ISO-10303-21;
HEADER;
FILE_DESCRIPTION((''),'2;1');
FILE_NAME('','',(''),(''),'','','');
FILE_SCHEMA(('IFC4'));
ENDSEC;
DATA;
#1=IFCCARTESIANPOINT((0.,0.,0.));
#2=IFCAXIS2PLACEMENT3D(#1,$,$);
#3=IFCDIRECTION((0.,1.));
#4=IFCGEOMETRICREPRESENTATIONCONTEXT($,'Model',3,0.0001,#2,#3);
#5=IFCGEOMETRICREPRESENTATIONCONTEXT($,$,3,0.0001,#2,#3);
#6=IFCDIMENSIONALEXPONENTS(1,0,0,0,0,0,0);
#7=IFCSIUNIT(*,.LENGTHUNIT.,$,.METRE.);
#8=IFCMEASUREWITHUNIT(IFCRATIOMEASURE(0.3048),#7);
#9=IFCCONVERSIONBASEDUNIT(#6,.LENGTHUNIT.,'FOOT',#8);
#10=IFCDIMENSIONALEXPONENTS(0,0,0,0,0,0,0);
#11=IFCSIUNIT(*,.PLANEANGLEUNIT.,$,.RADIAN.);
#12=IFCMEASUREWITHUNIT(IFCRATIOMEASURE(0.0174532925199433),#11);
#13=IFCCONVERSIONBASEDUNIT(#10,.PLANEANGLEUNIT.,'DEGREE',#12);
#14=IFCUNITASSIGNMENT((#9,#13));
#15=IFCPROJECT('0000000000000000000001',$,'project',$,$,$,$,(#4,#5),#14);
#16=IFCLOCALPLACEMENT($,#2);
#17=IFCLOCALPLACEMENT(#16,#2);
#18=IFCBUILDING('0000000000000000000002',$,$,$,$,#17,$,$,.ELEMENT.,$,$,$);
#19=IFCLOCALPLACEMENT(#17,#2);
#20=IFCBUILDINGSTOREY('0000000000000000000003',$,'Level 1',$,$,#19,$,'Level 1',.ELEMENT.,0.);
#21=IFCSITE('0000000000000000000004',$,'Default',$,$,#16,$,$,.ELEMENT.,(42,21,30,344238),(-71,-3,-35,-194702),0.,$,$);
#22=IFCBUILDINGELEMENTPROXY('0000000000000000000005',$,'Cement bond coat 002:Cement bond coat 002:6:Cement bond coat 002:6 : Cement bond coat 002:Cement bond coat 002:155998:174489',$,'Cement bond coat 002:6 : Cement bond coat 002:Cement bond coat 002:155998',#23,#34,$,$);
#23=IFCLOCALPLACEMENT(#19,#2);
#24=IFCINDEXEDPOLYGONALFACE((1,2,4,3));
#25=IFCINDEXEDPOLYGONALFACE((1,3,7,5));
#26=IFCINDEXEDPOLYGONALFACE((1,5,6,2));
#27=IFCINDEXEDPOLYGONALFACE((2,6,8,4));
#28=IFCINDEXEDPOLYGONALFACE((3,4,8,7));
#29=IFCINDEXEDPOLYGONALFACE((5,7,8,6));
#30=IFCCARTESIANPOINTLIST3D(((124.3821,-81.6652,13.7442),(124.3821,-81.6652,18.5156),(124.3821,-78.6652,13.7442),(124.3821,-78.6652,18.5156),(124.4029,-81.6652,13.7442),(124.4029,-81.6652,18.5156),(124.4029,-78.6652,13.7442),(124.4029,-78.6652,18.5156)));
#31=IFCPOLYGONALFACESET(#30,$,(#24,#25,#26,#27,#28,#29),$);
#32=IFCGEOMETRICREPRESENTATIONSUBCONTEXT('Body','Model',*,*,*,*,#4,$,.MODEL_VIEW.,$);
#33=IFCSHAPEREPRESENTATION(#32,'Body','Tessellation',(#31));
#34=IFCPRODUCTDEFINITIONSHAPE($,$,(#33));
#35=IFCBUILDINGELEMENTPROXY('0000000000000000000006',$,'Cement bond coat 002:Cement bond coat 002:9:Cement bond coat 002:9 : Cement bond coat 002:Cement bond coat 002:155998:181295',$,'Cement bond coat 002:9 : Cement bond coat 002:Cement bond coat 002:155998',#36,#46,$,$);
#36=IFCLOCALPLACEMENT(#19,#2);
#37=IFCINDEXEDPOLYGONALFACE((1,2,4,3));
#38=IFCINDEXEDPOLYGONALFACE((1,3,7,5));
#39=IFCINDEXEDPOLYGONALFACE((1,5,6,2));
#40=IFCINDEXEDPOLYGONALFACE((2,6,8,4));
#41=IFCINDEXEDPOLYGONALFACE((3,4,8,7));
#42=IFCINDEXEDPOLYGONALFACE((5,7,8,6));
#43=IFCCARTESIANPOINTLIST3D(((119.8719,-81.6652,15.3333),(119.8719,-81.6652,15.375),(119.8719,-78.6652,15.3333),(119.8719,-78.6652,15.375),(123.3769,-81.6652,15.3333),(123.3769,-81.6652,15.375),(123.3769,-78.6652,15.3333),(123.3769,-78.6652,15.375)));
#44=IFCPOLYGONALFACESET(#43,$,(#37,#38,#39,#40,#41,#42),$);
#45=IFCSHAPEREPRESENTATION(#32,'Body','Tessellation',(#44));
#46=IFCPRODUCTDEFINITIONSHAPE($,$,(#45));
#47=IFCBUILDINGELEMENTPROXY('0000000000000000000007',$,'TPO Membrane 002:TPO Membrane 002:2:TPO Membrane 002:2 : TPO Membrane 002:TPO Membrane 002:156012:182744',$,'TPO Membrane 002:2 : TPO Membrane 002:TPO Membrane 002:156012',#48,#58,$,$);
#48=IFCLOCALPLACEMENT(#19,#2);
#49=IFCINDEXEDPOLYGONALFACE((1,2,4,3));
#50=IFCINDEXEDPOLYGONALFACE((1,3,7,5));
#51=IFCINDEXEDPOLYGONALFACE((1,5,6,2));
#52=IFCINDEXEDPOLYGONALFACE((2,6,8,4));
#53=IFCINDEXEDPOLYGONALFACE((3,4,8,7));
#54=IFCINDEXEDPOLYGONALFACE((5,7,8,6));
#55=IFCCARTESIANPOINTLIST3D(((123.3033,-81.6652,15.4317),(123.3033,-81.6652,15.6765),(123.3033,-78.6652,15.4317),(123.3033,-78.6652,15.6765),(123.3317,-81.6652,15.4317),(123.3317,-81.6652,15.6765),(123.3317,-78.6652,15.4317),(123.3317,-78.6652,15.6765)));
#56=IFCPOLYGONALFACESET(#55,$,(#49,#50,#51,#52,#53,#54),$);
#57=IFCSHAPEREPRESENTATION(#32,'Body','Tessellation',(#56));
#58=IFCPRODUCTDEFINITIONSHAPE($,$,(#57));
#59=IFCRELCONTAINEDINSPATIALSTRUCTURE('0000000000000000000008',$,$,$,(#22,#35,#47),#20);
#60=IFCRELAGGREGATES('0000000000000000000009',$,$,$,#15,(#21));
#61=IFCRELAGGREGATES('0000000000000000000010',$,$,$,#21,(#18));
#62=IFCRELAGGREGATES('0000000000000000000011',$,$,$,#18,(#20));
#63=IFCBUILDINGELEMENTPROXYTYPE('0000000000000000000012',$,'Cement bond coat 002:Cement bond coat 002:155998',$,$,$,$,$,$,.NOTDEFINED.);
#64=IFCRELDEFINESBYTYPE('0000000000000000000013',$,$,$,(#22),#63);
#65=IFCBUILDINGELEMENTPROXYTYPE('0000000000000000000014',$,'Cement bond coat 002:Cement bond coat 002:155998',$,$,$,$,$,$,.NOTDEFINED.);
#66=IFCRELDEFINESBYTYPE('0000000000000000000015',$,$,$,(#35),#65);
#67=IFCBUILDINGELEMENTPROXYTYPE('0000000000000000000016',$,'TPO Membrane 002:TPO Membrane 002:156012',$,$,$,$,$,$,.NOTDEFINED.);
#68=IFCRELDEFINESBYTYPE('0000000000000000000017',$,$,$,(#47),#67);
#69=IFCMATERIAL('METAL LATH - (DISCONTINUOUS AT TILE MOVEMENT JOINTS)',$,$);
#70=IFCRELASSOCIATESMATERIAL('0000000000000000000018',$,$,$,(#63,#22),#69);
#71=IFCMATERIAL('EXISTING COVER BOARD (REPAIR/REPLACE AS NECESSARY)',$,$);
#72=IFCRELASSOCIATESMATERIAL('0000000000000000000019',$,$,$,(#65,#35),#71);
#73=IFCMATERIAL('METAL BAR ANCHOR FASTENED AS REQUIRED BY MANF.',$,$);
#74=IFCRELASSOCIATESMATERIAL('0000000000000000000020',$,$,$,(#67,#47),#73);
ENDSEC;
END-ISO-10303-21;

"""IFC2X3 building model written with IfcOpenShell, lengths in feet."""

from ifc_helpers import new_model, entity, si_unit, converted_unit, direction, frame, frame_2d, origin, origin_2d_with_axis, place, context, subcontext, project, spatial, rectangle, extrude, source, transform, mapped, material, type_object, type_shapes, element, save


model = new_model("IFC2X3")

# Units and contexts
model_context = context("Model", 3, precision=0.0001, world=origin(), true_north=direction((0.0, 1.0)))
context_of_model = context(None, 3, precision=0.0001, world=origin(), true_north=direction((0.0, 1.0)))
body_context = subcontext(model_context, "Body", "Model", "MODEL_VIEW")
ifc_project = project(units=[converted_unit("LENGTHUNIT", "FOOT", entity("IfcRatioMeasure", 0.3048), si_unit("LENGTHUNIT", "METRE"), dimensions=[1, 0, 0, 0, 0, 0, 0]), converted_unit("PLANEANGLEUNIT", "DEGREE", entity("IfcRatioMeasure", 0.0174532925199433), si_unit("PLANEANGLEUNIT", "RADIAN"), dimensions=[0, 0, 0, 0, 0, 0, 0])], contexts=[model_context, context_of_model])

# Site, building, storey
site_placement = place(None, origin())
site = spatial("IfcSite", under=ifc_project, at=site_placement, Name="Default", CompositionType="ELEMENT", RefLatitude=(42, 21, 30, 344238), RefLongitude=(-71, -3, -35, -194702), RefElevation=0.0)
building_placement = place(site_placement, origin())
building = spatial("IfcBuilding", under=site, at=building_placement, CompositionType="ELEMENT")
storey_placement = place(building_placement, origin())
storey = spatial("IfcBuildingStorey", under=building, at=storey_placement, Name="Level 1", LongName="Level 1", CompositionType="ELEMENT", Elevation=0.0)

# Building element proxies
ifc_material_1 = material(Name="METAL LATH - (DISCONTINUOUS AT TILE MOVEMENT JOINTS)")
building_element_proxy_type_1 = type_object("IfcBuildingElementProxyType", Name="Cement bond coat 002:Cement bond coat 002:155998", PredefinedType="NOTDEFINED", material=ifc_material_1)
shared_shape_1 = source(origin(), body_context, "Body", "SweptSolid", [
    extrude(rectangle(XDim=3.0, YDim=0.0208, at=origin_2d_with_axis()), frame((124.3925, -80.1652, 13.7442), z_axis=(0.0, 0.0, 1.0), x_axis=(0.0, 1.0, 0.0)), (0.0, 0.0, 1.0), 4.7715),
])
type_shapes(building_element_proxy_type_1, [shared_shape_1])
proxy_1_placement = place(storey_placement, origin())
element("IfcBuildingElementProxy", 1, at=proxy_1_placement, inside=storey, type_object=building_element_proxy_type_1, material=ifc_material_1, Name="Cement bond coat 002:Cement bond coat 002:6:Cement bond coat 002:6 : Cement bond coat 002:Cement bond coat 002:155998:174489", ObjectType="Cement bond coat 002:6 : Cement bond coat 002:Cement bond coat 002:155998", context=body_context, shape_type="MappedRepresentation", body=[
    mapped(shared_shape_1, transform((0.0, 0.0, 0.0), scale=1.0)),
])
ifc_material_2 = material(Name="EXISTING COVER BOARD (REPAIR/REPLACE AS NECESSARY)")
building_element_proxy_type_2 = type_object("IfcBuildingElementProxyType", Name="Cement bond coat 002:Cement bond coat 002:155998", PredefinedType="NOTDEFINED", material=ifc_material_2)
shared_shape_2 = source(origin(), body_context, "Body", "SweptSolid", [
    extrude(rectangle(XDim=3.0, YDim=3.505, at=frame_2d((0.0, 0.0), x_axis=(1.0, 0.0))), frame((121.6244, -80.1652, 15.3333), z_axis=(0.0, 0.0, 1.0), x_axis=(0.0, 1.0, 0.0)), (0.0, 0.0, 1.0), 0.0417),
])
type_shapes(building_element_proxy_type_2, [shared_shape_2])
proxy_2_placement = place(storey_placement, origin())
element("IfcBuildingElementProxy", 2, at=proxy_2_placement, inside=storey, type_object=building_element_proxy_type_2, material=ifc_material_2, Name="Cement bond coat 002:Cement bond coat 002:9:Cement bond coat 002:9 : Cement bond coat 002:Cement bond coat 002:155998:181295", ObjectType="Cement bond coat 002:9 : Cement bond coat 002:Cement bond coat 002:155998", context=body_context, shape_type="MappedRepresentation", body=[
    mapped(shared_shape_2, transform((0.0, 0.0, 0.0), scale=1.0)),
])
ifc_material_3 = material(Name="METAL BAR ANCHOR FASTENED AS REQUIRED BY MANF.")
building_element_proxy_type_3 = type_object("IfcBuildingElementProxyType", Name="TPO Membrane 002:TPO Membrane 002:156012", PredefinedType="NOTDEFINED", material=ifc_material_3)
shared_shape_3 = source(origin(), body_context, "Body", "SweptSolid", [
    extrude(rectangle(XDim=3.0, YDim=0.0284, at=origin_2d_with_axis()), frame((123.3175, -80.1652, 15.4317), z_axis=(0.0, 0.0, 1.0), x_axis=(0.0, -1.0, 0.0)), (0.0, 0.0, 1.0), 0.2449),
])
type_shapes(building_element_proxy_type_3, [shared_shape_3])
proxy_3_placement = place(storey_placement, origin())
element("IfcBuildingElementProxy", 3, at=proxy_3_placement, inside=storey, type_object=building_element_proxy_type_3, material=ifc_material_3, Name="TPO Membrane 002:TPO Membrane 002:2:TPO Membrane 002:2 : TPO Membrane 002:TPO Membrane 002:156012:182744", ObjectType="TPO Membrane 002:2 : TPO Membrane 002:TPO Membrane 002:156012", context=body_context, shape_type="MappedRepresentation", body=[
    mapped(shared_shape_3, transform((0.0, 0.0, 0.0), scale=1.0)),
])

save(model, "model.ifc")
